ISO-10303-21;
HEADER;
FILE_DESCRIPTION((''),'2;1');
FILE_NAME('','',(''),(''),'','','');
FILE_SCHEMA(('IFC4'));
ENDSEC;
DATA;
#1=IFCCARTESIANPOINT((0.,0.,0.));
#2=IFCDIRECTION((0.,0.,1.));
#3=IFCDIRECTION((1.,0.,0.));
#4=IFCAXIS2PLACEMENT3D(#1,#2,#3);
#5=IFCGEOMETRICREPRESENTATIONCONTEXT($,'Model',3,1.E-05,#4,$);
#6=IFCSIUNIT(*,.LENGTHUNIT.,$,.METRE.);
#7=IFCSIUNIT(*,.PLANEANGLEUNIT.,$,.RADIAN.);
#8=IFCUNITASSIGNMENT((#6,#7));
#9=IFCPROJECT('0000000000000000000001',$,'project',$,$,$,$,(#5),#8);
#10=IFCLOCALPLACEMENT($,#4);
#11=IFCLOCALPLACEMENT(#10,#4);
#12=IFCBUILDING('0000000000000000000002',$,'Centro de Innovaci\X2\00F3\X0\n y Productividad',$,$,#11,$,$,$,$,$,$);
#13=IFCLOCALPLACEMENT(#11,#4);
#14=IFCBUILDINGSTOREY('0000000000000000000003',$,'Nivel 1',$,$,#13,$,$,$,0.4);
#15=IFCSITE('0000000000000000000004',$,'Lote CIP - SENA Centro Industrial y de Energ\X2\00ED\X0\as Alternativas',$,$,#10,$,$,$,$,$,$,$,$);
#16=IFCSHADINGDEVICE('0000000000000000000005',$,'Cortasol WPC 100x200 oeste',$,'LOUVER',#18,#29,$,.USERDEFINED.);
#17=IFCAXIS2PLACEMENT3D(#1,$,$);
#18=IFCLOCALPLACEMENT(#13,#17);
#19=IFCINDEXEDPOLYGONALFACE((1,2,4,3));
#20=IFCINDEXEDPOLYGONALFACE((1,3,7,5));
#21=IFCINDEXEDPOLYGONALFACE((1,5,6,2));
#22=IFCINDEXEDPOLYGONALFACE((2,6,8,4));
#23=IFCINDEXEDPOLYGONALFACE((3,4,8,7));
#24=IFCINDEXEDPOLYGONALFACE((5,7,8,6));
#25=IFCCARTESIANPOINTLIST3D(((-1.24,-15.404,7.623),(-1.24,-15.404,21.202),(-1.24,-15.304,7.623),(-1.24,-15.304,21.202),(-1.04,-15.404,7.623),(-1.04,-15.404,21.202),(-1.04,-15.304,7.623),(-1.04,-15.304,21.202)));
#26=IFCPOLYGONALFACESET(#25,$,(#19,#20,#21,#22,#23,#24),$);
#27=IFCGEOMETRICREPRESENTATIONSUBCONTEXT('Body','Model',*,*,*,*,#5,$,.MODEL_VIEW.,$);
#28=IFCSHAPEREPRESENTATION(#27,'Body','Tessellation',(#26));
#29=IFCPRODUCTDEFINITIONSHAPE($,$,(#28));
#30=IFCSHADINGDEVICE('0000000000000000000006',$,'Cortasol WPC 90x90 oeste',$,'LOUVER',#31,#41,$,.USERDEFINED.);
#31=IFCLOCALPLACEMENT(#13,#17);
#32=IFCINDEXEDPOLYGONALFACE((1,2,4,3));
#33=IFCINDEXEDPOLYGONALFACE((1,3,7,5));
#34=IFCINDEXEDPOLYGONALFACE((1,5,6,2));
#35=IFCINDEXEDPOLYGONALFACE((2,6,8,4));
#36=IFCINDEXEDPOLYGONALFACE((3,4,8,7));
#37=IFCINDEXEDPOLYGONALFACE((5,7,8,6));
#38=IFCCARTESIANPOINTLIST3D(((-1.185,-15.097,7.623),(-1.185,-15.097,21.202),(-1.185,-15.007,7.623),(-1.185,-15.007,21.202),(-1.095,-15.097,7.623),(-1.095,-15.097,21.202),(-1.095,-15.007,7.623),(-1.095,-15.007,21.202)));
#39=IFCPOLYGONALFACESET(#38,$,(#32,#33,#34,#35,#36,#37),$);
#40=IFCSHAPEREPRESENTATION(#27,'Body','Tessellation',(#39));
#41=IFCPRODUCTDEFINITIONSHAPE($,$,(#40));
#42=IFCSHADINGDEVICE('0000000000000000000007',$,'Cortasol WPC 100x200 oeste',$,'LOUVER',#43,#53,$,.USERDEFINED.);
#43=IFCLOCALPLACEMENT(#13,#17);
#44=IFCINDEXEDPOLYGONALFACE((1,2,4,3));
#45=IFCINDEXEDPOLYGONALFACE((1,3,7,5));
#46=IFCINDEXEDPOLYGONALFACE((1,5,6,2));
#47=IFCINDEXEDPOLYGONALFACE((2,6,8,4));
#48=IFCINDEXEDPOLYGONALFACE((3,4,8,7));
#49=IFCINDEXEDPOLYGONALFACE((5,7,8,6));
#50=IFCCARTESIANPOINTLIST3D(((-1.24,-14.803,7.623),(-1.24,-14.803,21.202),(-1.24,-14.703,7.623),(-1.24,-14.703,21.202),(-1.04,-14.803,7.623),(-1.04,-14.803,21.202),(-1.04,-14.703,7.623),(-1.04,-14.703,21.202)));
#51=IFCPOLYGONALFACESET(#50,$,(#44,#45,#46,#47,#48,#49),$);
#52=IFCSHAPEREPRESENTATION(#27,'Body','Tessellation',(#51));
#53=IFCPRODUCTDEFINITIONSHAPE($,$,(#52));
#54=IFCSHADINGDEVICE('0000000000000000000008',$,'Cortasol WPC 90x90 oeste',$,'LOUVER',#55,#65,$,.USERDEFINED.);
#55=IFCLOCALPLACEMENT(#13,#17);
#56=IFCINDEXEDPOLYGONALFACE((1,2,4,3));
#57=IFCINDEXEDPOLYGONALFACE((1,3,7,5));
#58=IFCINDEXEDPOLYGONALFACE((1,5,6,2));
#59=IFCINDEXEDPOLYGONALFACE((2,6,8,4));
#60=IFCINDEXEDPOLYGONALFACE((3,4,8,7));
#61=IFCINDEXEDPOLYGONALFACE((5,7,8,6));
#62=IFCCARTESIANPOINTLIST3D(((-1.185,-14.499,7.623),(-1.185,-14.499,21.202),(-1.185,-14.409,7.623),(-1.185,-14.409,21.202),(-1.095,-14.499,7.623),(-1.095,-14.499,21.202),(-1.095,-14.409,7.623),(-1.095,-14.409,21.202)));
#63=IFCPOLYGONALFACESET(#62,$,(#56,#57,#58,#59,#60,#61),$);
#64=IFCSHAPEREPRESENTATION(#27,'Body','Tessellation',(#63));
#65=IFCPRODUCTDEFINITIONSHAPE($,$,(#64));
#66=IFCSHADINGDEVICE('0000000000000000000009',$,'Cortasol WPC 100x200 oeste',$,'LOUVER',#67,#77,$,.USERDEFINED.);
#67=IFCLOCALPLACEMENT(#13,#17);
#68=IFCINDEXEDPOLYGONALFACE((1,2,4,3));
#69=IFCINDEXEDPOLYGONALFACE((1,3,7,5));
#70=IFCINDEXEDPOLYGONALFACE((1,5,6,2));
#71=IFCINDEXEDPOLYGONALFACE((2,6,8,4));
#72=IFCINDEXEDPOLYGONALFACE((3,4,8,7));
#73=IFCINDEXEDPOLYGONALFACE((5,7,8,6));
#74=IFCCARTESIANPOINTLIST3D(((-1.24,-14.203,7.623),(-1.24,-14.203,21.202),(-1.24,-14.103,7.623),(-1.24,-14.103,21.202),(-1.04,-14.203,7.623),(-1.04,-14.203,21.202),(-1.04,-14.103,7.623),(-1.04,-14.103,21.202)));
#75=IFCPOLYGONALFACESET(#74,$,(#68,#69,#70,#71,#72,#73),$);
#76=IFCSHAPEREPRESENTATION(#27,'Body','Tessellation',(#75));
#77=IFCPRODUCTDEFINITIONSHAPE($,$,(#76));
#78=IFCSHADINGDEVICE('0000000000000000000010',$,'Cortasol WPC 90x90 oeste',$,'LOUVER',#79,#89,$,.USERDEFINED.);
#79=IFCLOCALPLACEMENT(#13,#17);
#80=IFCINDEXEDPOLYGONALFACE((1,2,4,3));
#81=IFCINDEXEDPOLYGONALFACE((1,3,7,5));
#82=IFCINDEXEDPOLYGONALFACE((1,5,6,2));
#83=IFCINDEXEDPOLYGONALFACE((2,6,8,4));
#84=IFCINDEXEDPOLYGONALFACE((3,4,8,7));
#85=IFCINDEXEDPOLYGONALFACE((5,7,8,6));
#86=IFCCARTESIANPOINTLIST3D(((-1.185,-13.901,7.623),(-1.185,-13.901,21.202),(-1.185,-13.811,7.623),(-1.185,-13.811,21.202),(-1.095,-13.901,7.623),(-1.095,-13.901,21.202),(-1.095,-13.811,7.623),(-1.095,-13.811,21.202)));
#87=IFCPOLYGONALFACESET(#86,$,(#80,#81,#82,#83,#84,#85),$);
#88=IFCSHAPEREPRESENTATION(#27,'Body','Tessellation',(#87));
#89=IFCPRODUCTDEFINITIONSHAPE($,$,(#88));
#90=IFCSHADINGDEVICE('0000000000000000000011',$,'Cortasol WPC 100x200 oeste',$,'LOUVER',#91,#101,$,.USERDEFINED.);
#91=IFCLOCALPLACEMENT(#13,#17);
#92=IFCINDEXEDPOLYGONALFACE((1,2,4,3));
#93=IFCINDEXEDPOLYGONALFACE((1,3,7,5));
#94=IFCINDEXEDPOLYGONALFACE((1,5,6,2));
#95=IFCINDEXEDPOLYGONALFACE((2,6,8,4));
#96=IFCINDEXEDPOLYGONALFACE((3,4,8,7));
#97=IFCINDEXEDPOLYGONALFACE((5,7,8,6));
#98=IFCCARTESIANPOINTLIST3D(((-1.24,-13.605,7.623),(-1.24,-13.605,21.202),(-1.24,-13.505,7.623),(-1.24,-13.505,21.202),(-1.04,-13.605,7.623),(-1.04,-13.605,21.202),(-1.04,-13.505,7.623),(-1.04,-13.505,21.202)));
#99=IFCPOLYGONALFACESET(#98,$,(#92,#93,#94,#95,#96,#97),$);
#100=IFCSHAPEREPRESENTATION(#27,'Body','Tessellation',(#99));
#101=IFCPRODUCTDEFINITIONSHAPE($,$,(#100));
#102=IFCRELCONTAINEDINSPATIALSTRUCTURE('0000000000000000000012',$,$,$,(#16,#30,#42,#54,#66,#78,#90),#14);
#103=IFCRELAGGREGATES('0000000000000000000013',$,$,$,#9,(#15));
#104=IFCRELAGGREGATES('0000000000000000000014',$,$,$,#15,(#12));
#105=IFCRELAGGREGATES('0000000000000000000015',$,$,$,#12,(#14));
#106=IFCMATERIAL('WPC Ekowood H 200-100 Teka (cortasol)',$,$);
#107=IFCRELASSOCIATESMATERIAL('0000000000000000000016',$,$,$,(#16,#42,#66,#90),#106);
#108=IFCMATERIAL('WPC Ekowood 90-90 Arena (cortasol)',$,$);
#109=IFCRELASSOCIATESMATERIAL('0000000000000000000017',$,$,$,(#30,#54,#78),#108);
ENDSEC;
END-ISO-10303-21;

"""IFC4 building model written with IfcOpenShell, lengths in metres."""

from ifc_helpers import new_model, si_unit, frame, origin_with_axes, place, context, subcontext, project, spatial, polyline, outline, extrude, material, element, save


model = new_model("IFC4")

# Units and contexts
model_context = context("Model", 3, precision=1e-05, world=origin_with_axes())
body_context = subcontext(model_context, "Body", "Model", "MODEL_VIEW")
ifc_project = project(units=[si_unit("LENGTHUNIT", "METRE"), si_unit("PLANEANGLEUNIT", "RADIAN")], contexts=[model_context])

# Site, building, storey
site_placement = place(None, origin_with_axes())
site = spatial("IfcSite", under=ifc_project, at=site_placement, Name="Lote CIP - SENA Centro Industrial y de Energías Alternativas")
building_placement = place(site_placement, origin_with_axes())
building = spatial("IfcBuilding", under=site, at=building_placement, Name="Centro de Innovación y Productividad")
storey_placement = place(building_placement, origin_with_axes())
storey = spatial("IfcBuildingStorey", under=building, at=storey_placement, Name="Nivel 1", Elevation=0.4)

# Shading devices
ifc_material_1 = material(Name="WPC Ekowood 90-90 Arena (cortasol)")
ifc_material_2 = material(Name="WPC Ekowood H 200-100 Teka (cortasol)")
shading_device_1_placement = place(storey_placement, origin_with_axes())
element("IfcShadingDevice", 1, at=shading_device_1_placement, inside=storey, material=ifc_material_2, Name="Cortasol WPC 100x200 oeste", ObjectType="LOUVER", PredefinedType="USERDEFINED", context=body_context, shape_type="SweptSolid", body=[
    extrude(outline(polyline([(-1.04, -15.404), (-1.24, -15.404), (-1.24, -15.304), (-1.04, -15.304), (-1.04, -15.404)])), frame((0.0, 0.0, 7.623)), (0.0, 0.0, 1.0), 13.579),
])
shading_device_2_placement = place(storey_placement, origin_with_axes())
element("IfcShadingDevice", 2, at=shading_device_2_placement, inside=storey, material=ifc_material_1, Name="Cortasol WPC 90x90 oeste", ObjectType="LOUVER", PredefinedType="USERDEFINED", context=body_context, shape_type="SweptSolid", body=[
    extrude(outline(polyline([(-1.095, -15.097), (-1.185, -15.097), (-1.185, -15.007), (-1.095, -15.007), (-1.095, -15.097)])), frame((0.0, 0.0, 7.623)), (0.0, 0.0, 1.0), 13.579),
])
shading_device_3_placement = place(storey_placement, origin_with_axes())
element("IfcShadingDevice", 3, at=shading_device_3_placement, inside=storey, material=ifc_material_2, Name="Cortasol WPC 100x200 oeste", ObjectType="LOUVER", PredefinedType="USERDEFINED", context=body_context, shape_type="SweptSolid", body=[
    extrude(outline(polyline([(-1.04, -14.803), (-1.24, -14.803), (-1.24, -14.703), (-1.04, -14.703), (-1.04, -14.803)])), frame((0.0, 0.0, 7.623)), (0.0, 0.0, 1.0), 13.579),
])
shading_device_4_placement = place(storey_placement, origin_with_axes())
element("IfcShadingDevice", 4, at=shading_device_4_placement, inside=storey, material=ifc_material_1, Name="Cortasol WPC 90x90 oeste", ObjectType="LOUVER", PredefinedType="USERDEFINED", context=body_context, shape_type="SweptSolid", body=[
    extrude(outline(polyline([(-1.095, -14.499), (-1.185, -14.499), (-1.185, -14.409), (-1.095, -14.409), (-1.095, -14.499)])), frame((0.0, 0.0, 7.623)), (0.0, 0.0, 1.0), 13.579),
])
shading_device_5_placement = place(storey_placement, origin_with_axes())
element("IfcShadingDevice", 5, at=shading_device_5_placement, inside=storey, material=ifc_material_2, Name="Cortasol WPC 100x200 oeste", ObjectType="LOUVER", PredefinedType="USERDEFINED", context=body_context, shape_type="SweptSolid", body=[
    extrude(outline(polyline([(-1.04, -14.203), (-1.24, -14.203), (-1.24, -14.103), (-1.04, -14.103), (-1.04, -14.203)])), frame((0.0, 0.0, 7.623)), (0.0, 0.0, 1.0), 13.579),
])
shading_device_6_placement = place(storey_placement, origin_with_axes())
element("IfcShadingDevice", 6, at=shading_device_6_placement, inside=storey, material=ifc_material_1, Name="Cortasol WPC 90x90 oeste", ObjectType="LOUVER", PredefinedType="USERDEFINED", context=body_context, shape_type="SweptSolid", body=[
    extrude(outline(polyline([(-1.095, -13.901), (-1.185, -13.901), (-1.185, -13.811), (-1.095, -13.811), (-1.095, -13.901)])), frame((0.0, 0.0, 7.623)), (0.0, 0.0, 1.0), 13.579),
])
shading_device_7_placement = place(storey_placement, origin_with_axes())
element("IfcShadingDevice", 7, at=shading_device_7_placement, inside=storey, material=ifc_material_2, Name="Cortasol WPC 100x200 oeste", ObjectType="LOUVER", PredefinedType="USERDEFINED", context=body_context, shape_type="SweptSolid", body=[
    extrude(outline(polyline([(-1.04, -13.605), (-1.24, -13.605), (-1.24, -13.505), (-1.04, -13.505), (-1.04, -13.605)])), frame((0.0, 0.0, 7.623)), (0.0, 0.0, 1.0), 13.579),
])

save(model, "model.ifc")
